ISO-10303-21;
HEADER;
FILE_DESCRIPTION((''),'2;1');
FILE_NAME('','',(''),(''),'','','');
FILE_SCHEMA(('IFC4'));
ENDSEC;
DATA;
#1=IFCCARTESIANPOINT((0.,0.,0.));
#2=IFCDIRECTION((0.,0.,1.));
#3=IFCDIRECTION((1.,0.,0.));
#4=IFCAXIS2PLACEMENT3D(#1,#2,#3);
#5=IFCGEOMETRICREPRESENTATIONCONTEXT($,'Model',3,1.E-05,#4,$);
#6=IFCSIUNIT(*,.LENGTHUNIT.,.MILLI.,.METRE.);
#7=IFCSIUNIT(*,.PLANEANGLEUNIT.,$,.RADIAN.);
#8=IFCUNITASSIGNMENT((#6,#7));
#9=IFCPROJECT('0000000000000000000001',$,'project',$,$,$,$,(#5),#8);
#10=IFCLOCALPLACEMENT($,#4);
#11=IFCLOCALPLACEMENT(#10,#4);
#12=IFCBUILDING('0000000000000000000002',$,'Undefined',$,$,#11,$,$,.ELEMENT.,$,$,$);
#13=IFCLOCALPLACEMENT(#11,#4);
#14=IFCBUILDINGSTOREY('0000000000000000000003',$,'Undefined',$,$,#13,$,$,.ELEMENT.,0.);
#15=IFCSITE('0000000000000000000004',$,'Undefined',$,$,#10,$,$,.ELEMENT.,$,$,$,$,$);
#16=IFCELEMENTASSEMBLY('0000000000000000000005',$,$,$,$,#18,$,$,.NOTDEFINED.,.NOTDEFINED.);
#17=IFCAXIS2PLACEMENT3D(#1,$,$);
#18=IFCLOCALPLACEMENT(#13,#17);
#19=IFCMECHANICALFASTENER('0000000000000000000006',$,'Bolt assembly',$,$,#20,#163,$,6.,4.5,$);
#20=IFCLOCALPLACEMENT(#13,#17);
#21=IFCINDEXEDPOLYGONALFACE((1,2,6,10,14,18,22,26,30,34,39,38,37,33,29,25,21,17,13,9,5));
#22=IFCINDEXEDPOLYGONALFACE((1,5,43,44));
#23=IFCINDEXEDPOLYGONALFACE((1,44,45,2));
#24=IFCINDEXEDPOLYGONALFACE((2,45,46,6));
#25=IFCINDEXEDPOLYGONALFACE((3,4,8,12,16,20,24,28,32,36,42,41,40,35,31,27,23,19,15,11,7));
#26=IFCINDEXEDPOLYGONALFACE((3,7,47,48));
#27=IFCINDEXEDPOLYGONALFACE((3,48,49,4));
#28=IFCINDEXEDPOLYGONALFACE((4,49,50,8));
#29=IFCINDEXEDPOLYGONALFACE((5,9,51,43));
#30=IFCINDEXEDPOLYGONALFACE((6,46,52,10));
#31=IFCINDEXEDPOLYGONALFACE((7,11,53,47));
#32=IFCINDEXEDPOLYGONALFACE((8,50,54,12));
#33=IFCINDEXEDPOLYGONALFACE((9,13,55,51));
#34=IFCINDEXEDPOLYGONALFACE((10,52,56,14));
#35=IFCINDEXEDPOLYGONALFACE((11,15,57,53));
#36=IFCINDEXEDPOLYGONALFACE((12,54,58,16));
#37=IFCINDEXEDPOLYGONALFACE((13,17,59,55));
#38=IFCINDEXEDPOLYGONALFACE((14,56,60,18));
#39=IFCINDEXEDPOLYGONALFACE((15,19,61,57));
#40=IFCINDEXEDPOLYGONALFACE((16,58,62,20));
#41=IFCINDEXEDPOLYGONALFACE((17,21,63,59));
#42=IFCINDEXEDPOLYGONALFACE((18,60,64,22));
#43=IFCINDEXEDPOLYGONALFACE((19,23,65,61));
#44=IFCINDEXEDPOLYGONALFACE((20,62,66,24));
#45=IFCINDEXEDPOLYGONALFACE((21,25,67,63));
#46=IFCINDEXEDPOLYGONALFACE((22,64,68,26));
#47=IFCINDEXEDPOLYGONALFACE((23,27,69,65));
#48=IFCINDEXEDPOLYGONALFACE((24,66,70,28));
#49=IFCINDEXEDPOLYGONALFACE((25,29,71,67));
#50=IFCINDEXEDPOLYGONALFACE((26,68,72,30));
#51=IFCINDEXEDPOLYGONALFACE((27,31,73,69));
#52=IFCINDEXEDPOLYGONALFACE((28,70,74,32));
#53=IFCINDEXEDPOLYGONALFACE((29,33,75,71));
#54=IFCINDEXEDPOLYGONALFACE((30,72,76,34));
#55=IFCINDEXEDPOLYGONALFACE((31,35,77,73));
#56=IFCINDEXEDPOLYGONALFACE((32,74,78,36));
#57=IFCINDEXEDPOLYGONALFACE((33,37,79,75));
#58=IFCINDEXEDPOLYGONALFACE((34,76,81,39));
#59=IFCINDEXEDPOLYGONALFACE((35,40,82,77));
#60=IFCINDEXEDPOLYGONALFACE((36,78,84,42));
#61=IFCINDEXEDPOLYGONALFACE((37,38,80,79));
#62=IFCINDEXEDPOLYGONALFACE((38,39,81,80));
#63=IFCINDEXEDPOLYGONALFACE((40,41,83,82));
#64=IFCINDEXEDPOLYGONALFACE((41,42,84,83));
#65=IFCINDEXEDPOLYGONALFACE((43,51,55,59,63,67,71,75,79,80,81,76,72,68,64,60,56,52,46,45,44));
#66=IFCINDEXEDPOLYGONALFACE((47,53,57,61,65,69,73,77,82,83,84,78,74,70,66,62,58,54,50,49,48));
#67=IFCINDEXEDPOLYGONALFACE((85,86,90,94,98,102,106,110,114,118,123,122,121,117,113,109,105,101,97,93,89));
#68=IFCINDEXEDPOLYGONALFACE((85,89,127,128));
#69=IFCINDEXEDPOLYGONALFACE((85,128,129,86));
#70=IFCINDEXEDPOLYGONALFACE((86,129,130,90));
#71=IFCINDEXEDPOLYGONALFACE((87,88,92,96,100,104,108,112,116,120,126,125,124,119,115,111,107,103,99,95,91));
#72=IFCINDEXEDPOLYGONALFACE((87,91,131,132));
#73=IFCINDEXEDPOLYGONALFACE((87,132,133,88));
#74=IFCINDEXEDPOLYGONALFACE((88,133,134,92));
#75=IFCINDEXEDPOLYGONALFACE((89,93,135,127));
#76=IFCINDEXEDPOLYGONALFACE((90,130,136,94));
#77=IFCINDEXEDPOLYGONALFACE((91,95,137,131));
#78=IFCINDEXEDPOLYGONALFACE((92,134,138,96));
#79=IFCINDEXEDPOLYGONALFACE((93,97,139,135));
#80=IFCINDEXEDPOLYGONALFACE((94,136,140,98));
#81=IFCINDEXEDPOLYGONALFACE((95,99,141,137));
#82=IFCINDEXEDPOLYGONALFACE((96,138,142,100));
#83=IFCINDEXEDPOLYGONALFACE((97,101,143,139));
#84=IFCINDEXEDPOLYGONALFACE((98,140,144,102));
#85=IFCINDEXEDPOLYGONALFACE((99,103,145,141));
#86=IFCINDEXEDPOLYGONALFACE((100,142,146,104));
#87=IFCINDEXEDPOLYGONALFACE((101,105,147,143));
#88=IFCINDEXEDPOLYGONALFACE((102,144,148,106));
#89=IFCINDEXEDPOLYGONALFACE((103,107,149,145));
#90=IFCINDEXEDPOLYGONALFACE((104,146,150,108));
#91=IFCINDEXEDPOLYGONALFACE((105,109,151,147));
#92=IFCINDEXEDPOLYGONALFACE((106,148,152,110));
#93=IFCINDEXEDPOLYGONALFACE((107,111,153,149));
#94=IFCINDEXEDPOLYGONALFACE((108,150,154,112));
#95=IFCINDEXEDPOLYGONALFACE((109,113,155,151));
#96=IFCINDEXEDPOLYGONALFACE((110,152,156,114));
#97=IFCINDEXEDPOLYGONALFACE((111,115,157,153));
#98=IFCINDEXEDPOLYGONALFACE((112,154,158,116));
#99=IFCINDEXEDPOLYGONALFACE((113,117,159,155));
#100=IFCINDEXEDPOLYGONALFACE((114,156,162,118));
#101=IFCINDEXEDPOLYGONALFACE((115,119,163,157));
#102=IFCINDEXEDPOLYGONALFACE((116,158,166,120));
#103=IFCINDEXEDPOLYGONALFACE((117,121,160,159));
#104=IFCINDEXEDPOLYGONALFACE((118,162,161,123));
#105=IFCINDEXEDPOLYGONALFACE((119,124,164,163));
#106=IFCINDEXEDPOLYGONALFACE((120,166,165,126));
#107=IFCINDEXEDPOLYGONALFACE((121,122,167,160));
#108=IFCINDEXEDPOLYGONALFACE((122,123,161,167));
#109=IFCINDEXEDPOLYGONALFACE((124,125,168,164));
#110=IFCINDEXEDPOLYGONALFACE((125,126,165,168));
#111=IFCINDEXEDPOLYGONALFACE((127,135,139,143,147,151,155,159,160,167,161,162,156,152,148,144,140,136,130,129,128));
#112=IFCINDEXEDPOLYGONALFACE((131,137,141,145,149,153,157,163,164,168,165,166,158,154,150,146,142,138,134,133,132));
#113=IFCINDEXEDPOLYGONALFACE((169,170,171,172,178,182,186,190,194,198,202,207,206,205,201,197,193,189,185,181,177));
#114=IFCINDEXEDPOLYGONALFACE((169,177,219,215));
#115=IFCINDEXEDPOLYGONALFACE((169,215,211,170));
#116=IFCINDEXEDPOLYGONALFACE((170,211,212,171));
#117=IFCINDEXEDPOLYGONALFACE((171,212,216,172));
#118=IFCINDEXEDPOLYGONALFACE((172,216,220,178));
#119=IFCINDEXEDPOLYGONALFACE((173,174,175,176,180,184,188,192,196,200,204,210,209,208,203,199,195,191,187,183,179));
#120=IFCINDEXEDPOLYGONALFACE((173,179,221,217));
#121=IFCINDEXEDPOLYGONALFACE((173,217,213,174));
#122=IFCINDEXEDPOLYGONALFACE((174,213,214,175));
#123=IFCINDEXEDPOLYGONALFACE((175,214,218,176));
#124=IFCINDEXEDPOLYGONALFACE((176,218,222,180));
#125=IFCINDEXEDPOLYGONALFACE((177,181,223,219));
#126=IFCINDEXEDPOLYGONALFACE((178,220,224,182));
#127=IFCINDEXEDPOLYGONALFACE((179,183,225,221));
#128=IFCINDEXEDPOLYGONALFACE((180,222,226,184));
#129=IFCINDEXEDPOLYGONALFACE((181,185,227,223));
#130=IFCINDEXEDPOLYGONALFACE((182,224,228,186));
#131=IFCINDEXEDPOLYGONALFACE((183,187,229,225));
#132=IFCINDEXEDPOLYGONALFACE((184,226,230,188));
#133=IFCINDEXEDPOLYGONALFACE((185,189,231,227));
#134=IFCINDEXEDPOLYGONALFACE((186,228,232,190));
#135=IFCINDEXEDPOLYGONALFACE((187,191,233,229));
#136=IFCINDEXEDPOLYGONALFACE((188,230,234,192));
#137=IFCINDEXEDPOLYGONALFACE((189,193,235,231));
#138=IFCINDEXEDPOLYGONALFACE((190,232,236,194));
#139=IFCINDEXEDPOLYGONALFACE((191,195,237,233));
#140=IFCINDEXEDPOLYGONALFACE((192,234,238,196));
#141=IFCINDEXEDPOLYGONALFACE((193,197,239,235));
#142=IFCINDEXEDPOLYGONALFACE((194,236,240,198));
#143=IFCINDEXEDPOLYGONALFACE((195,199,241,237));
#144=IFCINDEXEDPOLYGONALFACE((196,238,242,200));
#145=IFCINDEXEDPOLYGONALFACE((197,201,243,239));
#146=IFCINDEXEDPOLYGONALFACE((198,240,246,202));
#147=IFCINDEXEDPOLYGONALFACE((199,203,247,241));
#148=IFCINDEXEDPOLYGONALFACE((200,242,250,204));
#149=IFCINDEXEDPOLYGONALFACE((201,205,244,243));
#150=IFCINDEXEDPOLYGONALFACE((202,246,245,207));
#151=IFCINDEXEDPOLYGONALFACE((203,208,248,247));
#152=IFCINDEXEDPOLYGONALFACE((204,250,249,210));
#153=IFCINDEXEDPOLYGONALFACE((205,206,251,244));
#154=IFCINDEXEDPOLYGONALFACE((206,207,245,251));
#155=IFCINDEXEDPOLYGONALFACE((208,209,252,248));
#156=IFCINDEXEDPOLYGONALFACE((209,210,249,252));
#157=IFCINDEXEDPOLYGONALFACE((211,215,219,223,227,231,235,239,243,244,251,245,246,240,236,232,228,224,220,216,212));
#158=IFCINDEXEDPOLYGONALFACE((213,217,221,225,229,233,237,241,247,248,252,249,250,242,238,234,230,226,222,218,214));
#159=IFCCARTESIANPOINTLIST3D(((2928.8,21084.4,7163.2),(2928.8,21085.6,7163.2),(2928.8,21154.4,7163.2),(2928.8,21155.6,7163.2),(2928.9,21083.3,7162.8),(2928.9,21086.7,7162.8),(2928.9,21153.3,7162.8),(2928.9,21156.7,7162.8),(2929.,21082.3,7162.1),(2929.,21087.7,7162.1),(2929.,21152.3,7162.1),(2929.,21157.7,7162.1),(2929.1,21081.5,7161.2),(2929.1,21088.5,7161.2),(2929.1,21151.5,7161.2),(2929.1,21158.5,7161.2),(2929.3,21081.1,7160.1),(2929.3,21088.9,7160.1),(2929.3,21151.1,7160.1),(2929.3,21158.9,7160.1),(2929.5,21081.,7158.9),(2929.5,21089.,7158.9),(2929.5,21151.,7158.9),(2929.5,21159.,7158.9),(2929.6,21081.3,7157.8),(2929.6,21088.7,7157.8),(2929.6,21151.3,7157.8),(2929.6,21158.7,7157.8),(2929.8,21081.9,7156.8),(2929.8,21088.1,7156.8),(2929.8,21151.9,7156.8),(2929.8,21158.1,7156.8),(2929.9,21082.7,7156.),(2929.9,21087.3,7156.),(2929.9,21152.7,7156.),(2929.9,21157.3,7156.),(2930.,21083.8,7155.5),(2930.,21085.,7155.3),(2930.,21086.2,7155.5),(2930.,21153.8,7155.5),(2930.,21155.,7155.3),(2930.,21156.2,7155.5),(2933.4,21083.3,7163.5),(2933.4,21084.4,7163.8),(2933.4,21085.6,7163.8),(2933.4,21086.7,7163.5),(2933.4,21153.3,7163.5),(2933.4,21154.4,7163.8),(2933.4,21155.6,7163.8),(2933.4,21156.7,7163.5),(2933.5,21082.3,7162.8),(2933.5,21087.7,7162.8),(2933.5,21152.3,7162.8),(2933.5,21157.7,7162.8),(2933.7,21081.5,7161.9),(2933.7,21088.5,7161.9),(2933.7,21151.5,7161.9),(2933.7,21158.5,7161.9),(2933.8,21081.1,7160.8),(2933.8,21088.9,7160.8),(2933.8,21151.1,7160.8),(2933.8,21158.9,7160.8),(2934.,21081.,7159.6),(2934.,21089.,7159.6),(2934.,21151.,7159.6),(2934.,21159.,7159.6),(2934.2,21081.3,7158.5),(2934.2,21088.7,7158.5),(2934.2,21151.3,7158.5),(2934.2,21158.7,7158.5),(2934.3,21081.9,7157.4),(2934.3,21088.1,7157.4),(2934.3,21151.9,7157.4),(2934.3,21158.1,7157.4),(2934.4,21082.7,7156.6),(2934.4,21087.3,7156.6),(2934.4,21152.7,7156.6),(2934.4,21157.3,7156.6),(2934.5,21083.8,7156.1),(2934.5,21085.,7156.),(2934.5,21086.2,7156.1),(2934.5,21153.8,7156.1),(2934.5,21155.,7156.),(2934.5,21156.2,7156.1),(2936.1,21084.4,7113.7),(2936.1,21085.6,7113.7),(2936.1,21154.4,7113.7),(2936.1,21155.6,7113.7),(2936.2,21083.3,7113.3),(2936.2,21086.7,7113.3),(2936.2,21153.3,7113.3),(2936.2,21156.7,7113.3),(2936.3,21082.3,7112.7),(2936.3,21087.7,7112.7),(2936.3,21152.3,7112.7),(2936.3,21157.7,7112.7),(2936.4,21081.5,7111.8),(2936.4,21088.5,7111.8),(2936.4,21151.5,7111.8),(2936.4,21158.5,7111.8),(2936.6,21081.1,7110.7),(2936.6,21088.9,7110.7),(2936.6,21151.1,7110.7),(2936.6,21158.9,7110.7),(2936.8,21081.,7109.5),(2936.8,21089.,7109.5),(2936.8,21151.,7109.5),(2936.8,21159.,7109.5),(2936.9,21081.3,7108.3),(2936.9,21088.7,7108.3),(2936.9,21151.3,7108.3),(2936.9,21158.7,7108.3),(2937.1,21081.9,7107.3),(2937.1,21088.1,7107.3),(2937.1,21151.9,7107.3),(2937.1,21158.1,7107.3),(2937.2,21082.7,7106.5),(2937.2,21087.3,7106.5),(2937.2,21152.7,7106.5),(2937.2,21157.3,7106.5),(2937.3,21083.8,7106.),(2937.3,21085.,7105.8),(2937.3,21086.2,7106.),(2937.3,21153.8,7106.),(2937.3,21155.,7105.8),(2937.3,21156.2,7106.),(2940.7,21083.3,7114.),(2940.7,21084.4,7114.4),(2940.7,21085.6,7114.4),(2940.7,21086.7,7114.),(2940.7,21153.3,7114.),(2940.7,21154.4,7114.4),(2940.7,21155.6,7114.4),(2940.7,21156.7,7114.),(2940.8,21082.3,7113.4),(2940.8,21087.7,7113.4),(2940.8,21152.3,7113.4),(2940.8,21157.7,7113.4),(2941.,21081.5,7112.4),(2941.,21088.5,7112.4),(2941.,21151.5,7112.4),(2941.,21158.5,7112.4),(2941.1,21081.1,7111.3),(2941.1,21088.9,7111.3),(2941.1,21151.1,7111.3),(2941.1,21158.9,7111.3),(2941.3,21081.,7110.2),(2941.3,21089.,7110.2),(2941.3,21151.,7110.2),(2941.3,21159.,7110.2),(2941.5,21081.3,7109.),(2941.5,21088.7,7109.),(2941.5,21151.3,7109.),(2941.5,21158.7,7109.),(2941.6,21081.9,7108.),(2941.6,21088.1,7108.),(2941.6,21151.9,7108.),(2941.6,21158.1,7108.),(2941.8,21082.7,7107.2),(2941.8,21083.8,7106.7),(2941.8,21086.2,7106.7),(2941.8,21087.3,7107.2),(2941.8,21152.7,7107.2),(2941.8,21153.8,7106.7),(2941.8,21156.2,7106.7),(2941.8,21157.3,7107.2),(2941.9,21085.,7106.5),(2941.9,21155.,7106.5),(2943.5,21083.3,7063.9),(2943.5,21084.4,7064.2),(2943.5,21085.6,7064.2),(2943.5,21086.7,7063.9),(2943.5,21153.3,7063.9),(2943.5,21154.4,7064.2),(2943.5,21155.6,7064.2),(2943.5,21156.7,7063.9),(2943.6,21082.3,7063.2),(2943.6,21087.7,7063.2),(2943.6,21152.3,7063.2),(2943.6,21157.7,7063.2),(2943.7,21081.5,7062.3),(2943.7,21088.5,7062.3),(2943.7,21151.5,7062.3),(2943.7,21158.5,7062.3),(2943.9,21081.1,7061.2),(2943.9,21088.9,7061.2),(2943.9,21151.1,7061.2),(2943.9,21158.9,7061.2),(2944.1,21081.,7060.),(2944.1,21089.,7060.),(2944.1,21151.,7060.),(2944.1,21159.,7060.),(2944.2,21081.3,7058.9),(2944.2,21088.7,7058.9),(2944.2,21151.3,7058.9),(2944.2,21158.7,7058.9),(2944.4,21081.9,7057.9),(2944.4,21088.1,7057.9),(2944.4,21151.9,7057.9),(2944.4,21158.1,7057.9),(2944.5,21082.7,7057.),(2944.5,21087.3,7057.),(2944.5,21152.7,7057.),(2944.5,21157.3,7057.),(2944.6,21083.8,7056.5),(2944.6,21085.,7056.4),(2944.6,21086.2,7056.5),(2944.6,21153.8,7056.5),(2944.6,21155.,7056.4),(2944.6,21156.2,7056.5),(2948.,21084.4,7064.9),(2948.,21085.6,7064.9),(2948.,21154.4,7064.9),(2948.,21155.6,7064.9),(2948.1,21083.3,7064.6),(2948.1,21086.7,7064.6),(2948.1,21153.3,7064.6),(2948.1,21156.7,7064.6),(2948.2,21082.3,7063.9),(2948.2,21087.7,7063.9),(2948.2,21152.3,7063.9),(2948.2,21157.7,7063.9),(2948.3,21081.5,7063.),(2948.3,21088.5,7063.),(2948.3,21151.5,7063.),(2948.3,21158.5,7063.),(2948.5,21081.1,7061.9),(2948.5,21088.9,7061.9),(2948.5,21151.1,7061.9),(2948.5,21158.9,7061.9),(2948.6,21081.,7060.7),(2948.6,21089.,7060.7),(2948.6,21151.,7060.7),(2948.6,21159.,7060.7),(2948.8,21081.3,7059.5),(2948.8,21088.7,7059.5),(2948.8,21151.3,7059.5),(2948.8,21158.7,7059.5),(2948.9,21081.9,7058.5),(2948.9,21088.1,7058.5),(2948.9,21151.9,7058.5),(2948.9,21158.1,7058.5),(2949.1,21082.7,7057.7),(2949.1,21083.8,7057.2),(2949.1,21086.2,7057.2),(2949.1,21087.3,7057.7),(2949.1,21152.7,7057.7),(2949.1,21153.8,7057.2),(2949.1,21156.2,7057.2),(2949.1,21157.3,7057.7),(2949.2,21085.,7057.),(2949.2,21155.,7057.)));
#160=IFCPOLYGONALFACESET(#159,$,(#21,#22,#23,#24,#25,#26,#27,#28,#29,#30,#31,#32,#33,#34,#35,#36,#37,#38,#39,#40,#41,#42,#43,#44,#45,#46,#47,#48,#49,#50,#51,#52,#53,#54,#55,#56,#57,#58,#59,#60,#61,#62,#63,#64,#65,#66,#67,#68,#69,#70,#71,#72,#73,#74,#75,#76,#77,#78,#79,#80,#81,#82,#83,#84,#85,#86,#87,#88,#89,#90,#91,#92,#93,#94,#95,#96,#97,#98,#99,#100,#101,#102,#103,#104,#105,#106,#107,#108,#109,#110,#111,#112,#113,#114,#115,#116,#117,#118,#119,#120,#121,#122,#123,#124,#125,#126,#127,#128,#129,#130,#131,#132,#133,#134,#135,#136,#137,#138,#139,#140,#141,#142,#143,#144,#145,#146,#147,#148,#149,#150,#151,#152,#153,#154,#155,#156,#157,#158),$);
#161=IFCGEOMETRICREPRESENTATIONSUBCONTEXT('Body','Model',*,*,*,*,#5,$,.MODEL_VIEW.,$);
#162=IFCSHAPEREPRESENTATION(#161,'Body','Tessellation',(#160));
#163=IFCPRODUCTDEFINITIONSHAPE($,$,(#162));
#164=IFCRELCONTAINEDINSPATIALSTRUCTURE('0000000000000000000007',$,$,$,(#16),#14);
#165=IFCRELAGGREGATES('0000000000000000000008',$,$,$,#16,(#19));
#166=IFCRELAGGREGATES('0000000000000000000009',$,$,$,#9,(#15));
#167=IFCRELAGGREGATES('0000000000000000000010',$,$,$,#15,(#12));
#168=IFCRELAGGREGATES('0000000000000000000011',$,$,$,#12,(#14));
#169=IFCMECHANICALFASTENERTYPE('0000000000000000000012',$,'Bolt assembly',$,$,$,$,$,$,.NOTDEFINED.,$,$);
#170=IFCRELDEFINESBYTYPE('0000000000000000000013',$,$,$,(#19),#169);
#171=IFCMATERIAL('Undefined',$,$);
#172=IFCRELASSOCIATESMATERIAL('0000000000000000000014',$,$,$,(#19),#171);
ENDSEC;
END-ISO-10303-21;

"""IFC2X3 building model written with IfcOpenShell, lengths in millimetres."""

from ifc_helpers import new_model, si_unit, frame, origin_with_axes, origin_2d_with_axis, place, context, subcontext, project, spatial, circle, extrude, source, transform, mapped, material, type_object, element, aggregate, save


model = new_model("IFC2X3")

# Units and contexts
model_context = context("Model", 3, precision=1e-05, world=origin_with_axes())
body_context = subcontext(model_context, "Body", "Model", "MODEL_VIEW")
ifc_project = project(units=[si_unit("LENGTHUNIT", "METRE", prefix="MILLI"), si_unit("PLANEANGLEUNIT", "RADIAN")], contexts=[model_context])

# Site, building, storey
site_placement = place(None, origin_with_axes())
site = spatial("IfcSite", under=ifc_project, at=site_placement, Name="Undefined", CompositionType="ELEMENT")
building_placement = place(site_placement, origin_with_axes())
building = spatial("IfcBuilding", under=site, at=building_placement, Name="Undefined", CompositionType="ELEMENT")
storey_placement = place(building_placement, origin_with_axes())
storey = spatial("IfcBuildingStorey", under=building, at=storey_placement, Name="Undefined", CompositionType="ELEMENT", Elevation=0.0)

# Element assembly
assembly_1_placement = place(storey_placement, origin_with_axes())
assembly_1 = element("IfcElementAssembly", 1, at=assembly_1_placement, inside=storey, AssemblyPlace="NOTDEFINED", PredefinedType="NOTDEFINED")

# Mechanical fastener
ifc_material_1 = material(Name="Undefined")
mechanical_fastener_type = type_object("IfcMechanicalFastenerType", Name="Bolt assembly")
shared_shape_1 = source(origin_with_axes(), body_context, "Body", "SweptSolid", [
    extrude(circle(Radius=4.0, at=origin_2d_with_axis()), frame((0.0, 0.0, 0.0), z_axis=(0.0, 1.0, 0.0), x_axis=(1.0, 0.0, 0.0)), (0.0, 0.0, 1.0), 4.6),
])
mechanical_fastener_1_placement = place(assembly_1_placement, frame((2929.4, 21120.0, 7159.2), z_axis=(0.0, -1.0, 0.0), x_axis=(0.146203, 0.0, -0.989255)))
mechanical_fastener_1 = element("IfcMechanicalFastener", 2, at=mechanical_fastener_1_placement, type_object=mechanical_fastener_type, material=ifc_material_1, Name="Bolt assembly", NominalDiameter=6.0, NominalLength=4.5, context=body_context, shape_type="MappedRepresentation", body=[
    mapped(shared_shape_1, transform((0.0, 0.0, -35.0))),
    mapped(shared_shape_1, transform((50.0, 0.0, -35.0))),
    mapped(shared_shape_1, transform((100.0, 0.0, -35.0))),
    mapped(shared_shape_1, transform((0.0, 0.0, 35.0))),
    mapped(shared_shape_1, transform((50.0, 0.0, 35.0))),
    mapped(shared_shape_1, transform((100.0, 0.0, 35.0))),
])

aggregate(assembly_1, [mechanical_fastener_1])

save(model, "model.ifc")
